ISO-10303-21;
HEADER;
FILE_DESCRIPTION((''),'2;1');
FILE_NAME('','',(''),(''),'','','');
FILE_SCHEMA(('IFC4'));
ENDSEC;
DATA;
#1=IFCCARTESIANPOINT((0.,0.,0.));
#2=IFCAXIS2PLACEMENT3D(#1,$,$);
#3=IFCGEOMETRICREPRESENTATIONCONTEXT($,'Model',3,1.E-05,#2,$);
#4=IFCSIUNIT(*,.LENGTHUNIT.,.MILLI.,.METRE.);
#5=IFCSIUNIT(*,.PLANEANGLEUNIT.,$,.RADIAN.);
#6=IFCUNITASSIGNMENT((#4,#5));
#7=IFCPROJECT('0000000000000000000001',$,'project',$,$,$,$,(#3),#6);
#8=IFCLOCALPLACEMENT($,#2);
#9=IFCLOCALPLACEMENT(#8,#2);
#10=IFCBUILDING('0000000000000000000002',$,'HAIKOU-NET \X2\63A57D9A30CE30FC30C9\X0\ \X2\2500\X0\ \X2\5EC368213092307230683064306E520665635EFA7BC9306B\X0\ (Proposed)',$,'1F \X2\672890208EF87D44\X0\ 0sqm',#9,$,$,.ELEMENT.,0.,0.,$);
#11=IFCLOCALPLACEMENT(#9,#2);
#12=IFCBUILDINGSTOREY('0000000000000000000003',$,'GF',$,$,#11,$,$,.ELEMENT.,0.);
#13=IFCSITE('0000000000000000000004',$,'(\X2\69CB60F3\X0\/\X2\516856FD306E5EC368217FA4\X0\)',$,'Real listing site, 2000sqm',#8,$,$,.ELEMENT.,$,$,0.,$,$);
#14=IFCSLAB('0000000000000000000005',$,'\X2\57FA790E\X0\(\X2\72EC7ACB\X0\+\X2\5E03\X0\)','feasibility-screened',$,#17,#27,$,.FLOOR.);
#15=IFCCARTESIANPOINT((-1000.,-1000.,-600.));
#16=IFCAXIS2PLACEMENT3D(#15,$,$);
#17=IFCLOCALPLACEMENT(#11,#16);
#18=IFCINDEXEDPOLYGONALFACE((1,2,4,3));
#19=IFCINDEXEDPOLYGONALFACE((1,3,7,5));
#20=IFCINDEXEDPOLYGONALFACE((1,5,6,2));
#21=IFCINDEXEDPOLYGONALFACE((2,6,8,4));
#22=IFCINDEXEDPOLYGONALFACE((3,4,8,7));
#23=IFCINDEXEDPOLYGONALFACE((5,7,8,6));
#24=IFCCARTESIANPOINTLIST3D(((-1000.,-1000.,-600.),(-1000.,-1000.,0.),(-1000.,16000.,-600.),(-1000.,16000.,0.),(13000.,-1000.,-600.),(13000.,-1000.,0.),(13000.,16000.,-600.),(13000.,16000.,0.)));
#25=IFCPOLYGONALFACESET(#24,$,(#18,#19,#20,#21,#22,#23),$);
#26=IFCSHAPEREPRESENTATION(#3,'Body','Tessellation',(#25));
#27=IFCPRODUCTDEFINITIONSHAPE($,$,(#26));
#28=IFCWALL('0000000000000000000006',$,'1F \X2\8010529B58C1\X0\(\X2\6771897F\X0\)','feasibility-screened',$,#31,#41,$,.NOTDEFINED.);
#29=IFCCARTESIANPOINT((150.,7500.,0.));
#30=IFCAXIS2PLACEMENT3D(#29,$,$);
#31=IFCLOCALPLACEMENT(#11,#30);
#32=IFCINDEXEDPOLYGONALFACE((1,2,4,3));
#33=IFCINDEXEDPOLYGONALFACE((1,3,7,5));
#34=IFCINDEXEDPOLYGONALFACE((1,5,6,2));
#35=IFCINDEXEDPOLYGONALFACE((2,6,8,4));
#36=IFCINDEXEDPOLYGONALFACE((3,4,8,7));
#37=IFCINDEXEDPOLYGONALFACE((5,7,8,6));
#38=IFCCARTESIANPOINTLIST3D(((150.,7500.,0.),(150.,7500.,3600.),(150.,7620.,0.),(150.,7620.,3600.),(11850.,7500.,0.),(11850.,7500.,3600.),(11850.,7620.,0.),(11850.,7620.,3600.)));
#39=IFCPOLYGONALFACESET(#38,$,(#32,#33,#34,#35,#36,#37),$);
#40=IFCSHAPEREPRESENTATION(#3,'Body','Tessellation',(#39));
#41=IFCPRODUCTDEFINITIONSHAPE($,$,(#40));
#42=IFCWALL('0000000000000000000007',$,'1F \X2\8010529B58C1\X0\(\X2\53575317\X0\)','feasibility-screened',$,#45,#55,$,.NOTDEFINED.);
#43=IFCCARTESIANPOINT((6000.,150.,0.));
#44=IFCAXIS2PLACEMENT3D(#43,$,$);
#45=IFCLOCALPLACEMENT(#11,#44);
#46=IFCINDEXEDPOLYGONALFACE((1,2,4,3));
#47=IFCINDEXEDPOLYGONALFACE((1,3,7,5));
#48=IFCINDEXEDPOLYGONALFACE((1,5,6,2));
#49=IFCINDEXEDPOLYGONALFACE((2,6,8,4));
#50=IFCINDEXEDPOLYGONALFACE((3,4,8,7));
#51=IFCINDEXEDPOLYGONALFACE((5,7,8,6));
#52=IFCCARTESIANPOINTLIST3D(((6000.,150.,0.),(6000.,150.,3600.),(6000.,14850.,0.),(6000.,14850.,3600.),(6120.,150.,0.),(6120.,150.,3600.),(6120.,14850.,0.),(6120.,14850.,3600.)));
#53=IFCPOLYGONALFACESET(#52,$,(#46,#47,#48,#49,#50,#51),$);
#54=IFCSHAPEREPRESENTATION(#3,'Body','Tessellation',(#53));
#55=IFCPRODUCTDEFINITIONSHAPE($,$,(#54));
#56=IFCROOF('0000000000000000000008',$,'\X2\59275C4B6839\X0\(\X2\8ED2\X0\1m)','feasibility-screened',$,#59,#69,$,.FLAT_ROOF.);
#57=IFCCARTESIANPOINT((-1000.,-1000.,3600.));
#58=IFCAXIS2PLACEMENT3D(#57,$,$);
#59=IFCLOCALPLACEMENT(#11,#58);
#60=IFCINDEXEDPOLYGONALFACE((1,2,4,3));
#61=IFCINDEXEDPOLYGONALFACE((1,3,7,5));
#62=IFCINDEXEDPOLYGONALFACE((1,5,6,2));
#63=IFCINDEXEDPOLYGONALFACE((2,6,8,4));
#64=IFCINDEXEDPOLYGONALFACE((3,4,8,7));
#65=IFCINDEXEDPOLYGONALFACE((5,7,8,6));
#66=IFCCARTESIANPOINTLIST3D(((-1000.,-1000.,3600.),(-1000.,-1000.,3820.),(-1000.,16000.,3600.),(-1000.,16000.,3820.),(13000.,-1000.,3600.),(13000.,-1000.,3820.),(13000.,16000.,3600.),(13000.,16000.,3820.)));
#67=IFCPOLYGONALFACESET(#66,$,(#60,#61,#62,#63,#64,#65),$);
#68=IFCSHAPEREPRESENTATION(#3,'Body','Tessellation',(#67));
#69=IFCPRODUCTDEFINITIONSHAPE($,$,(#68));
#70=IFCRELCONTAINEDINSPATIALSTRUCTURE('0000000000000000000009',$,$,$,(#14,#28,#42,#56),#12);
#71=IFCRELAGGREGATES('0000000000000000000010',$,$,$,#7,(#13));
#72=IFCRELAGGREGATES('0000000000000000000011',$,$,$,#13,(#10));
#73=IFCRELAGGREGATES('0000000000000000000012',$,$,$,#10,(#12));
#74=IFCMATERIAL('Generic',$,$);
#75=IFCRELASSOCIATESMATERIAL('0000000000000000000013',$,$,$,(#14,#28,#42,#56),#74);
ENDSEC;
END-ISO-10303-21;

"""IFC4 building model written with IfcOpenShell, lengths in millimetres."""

from ifc_helpers import new_model, si_unit, frame, frame_2d, origin, place, context, project, spatial, rectangle, extrude, material, element, save


model = new_model("IFC4")

# Units and contexts
model_context = context("Model", 3, precision=1e-05, world=origin())
ifc_project = project(units=[si_unit("LENGTHUNIT", "METRE", prefix="MILLI"), si_unit("PLANEANGLEUNIT", "RADIAN")], contexts=[model_context])

# Site, building, storey
site_placement = place(None, origin())
site = spatial("IfcSite", under=ifc_project, at=site_placement, Name="(構想/全国の廃校群)", ObjectType="Real listing site, 2000sqm", CompositionType="ELEMENT", RefElevation=0.0)
building_placement = place(site_placement, origin())
building = spatial("IfcBuilding", under=site, at=building_placement, Name="HAIKOU-NET 接続ノード ─ 廃校をひとつの分散建築に (Proposed)", ObjectType="1F 木造軸組 0sqm", CompositionType="ELEMENT", ElevationOfRefHeight=0.0, ElevationOfTerrain=0.0)
storey_placement = place(building_placement, origin())
storey = spatial("IfcBuildingStorey", under=building, at=storey_placement, Name="GF", CompositionType="ELEMENT", Elevation=0.0)

# Slab
ifc_material = material(Name="Generic")
slab_1_placement = place(storey_placement, frame((-1000.0, -1000.0, -600.0)))
element("IfcSlab", 1, at=slab_1_placement, inside=storey, material=ifc_material, Name="基礎(独立+布)", Description="feasibility-screened", PredefinedType="FLOOR", context=model_context, shape_type="SweptSolid", body=[
    extrude(rectangle(XDim=14000.0, YDim=17000.0, at=frame_2d((7000.0, 8500.0))), frame((-1000.0, -1000.0, -600.0)), (0.0, 0.0, 1.0), 600.0),
])

# Walls
wall_1_placement = place(storey_placement, frame((150.0, 7500.0, 0.0)))
element("IfcWall", 2, at=wall_1_placement, inside=storey, material=ifc_material, Name="1F 耐力壁(東西)", Description="feasibility-screened", PredefinedType="NOTDEFINED", context=model_context, shape_type="SweptSolid", body=[
    extrude(rectangle(XDim=11700.0, YDim=120.0, at=frame_2d((5850.0, 60.0))), frame((150.0, 7500.0, 0.0)), (0.0, 0.0, 1.0), 3600.0),
])
wall_2_placement = place(storey_placement, frame((6000.0, 150.0, 0.0)))
element("IfcWall", 3, at=wall_2_placement, inside=storey, material=ifc_material, Name="1F 耐力壁(南北)", Description="feasibility-screened", PredefinedType="NOTDEFINED", context=model_context, shape_type="SweptSolid", body=[
    extrude(rectangle(XDim=120.0, YDim=14700.0, at=frame_2d((60.0, 7350.0))), frame((6000.0, 150.0, 0.0)), (0.0, 0.0, 1.0), 3600.0),
])

# Roof
roof_placement = place(storey_placement, frame((-1000.0, -1000.0, 3600.0)))
element("IfcRoof", 4, at=roof_placement, inside=storey, material=ifc_material, Name="大屋根(軒1m)", Description="feasibility-screened", PredefinedType="FLAT_ROOF", context=model_context, shape_type="SweptSolid", body=[
    extrude(rectangle(XDim=14000.0, YDim=17000.0, at=frame_2d((7000.0, 8500.0))), frame((-1000.0, -1000.0, 3600.0)), (0.0, 0.0, 1.0), 220.0),
])

save(model, "model.ifc")
